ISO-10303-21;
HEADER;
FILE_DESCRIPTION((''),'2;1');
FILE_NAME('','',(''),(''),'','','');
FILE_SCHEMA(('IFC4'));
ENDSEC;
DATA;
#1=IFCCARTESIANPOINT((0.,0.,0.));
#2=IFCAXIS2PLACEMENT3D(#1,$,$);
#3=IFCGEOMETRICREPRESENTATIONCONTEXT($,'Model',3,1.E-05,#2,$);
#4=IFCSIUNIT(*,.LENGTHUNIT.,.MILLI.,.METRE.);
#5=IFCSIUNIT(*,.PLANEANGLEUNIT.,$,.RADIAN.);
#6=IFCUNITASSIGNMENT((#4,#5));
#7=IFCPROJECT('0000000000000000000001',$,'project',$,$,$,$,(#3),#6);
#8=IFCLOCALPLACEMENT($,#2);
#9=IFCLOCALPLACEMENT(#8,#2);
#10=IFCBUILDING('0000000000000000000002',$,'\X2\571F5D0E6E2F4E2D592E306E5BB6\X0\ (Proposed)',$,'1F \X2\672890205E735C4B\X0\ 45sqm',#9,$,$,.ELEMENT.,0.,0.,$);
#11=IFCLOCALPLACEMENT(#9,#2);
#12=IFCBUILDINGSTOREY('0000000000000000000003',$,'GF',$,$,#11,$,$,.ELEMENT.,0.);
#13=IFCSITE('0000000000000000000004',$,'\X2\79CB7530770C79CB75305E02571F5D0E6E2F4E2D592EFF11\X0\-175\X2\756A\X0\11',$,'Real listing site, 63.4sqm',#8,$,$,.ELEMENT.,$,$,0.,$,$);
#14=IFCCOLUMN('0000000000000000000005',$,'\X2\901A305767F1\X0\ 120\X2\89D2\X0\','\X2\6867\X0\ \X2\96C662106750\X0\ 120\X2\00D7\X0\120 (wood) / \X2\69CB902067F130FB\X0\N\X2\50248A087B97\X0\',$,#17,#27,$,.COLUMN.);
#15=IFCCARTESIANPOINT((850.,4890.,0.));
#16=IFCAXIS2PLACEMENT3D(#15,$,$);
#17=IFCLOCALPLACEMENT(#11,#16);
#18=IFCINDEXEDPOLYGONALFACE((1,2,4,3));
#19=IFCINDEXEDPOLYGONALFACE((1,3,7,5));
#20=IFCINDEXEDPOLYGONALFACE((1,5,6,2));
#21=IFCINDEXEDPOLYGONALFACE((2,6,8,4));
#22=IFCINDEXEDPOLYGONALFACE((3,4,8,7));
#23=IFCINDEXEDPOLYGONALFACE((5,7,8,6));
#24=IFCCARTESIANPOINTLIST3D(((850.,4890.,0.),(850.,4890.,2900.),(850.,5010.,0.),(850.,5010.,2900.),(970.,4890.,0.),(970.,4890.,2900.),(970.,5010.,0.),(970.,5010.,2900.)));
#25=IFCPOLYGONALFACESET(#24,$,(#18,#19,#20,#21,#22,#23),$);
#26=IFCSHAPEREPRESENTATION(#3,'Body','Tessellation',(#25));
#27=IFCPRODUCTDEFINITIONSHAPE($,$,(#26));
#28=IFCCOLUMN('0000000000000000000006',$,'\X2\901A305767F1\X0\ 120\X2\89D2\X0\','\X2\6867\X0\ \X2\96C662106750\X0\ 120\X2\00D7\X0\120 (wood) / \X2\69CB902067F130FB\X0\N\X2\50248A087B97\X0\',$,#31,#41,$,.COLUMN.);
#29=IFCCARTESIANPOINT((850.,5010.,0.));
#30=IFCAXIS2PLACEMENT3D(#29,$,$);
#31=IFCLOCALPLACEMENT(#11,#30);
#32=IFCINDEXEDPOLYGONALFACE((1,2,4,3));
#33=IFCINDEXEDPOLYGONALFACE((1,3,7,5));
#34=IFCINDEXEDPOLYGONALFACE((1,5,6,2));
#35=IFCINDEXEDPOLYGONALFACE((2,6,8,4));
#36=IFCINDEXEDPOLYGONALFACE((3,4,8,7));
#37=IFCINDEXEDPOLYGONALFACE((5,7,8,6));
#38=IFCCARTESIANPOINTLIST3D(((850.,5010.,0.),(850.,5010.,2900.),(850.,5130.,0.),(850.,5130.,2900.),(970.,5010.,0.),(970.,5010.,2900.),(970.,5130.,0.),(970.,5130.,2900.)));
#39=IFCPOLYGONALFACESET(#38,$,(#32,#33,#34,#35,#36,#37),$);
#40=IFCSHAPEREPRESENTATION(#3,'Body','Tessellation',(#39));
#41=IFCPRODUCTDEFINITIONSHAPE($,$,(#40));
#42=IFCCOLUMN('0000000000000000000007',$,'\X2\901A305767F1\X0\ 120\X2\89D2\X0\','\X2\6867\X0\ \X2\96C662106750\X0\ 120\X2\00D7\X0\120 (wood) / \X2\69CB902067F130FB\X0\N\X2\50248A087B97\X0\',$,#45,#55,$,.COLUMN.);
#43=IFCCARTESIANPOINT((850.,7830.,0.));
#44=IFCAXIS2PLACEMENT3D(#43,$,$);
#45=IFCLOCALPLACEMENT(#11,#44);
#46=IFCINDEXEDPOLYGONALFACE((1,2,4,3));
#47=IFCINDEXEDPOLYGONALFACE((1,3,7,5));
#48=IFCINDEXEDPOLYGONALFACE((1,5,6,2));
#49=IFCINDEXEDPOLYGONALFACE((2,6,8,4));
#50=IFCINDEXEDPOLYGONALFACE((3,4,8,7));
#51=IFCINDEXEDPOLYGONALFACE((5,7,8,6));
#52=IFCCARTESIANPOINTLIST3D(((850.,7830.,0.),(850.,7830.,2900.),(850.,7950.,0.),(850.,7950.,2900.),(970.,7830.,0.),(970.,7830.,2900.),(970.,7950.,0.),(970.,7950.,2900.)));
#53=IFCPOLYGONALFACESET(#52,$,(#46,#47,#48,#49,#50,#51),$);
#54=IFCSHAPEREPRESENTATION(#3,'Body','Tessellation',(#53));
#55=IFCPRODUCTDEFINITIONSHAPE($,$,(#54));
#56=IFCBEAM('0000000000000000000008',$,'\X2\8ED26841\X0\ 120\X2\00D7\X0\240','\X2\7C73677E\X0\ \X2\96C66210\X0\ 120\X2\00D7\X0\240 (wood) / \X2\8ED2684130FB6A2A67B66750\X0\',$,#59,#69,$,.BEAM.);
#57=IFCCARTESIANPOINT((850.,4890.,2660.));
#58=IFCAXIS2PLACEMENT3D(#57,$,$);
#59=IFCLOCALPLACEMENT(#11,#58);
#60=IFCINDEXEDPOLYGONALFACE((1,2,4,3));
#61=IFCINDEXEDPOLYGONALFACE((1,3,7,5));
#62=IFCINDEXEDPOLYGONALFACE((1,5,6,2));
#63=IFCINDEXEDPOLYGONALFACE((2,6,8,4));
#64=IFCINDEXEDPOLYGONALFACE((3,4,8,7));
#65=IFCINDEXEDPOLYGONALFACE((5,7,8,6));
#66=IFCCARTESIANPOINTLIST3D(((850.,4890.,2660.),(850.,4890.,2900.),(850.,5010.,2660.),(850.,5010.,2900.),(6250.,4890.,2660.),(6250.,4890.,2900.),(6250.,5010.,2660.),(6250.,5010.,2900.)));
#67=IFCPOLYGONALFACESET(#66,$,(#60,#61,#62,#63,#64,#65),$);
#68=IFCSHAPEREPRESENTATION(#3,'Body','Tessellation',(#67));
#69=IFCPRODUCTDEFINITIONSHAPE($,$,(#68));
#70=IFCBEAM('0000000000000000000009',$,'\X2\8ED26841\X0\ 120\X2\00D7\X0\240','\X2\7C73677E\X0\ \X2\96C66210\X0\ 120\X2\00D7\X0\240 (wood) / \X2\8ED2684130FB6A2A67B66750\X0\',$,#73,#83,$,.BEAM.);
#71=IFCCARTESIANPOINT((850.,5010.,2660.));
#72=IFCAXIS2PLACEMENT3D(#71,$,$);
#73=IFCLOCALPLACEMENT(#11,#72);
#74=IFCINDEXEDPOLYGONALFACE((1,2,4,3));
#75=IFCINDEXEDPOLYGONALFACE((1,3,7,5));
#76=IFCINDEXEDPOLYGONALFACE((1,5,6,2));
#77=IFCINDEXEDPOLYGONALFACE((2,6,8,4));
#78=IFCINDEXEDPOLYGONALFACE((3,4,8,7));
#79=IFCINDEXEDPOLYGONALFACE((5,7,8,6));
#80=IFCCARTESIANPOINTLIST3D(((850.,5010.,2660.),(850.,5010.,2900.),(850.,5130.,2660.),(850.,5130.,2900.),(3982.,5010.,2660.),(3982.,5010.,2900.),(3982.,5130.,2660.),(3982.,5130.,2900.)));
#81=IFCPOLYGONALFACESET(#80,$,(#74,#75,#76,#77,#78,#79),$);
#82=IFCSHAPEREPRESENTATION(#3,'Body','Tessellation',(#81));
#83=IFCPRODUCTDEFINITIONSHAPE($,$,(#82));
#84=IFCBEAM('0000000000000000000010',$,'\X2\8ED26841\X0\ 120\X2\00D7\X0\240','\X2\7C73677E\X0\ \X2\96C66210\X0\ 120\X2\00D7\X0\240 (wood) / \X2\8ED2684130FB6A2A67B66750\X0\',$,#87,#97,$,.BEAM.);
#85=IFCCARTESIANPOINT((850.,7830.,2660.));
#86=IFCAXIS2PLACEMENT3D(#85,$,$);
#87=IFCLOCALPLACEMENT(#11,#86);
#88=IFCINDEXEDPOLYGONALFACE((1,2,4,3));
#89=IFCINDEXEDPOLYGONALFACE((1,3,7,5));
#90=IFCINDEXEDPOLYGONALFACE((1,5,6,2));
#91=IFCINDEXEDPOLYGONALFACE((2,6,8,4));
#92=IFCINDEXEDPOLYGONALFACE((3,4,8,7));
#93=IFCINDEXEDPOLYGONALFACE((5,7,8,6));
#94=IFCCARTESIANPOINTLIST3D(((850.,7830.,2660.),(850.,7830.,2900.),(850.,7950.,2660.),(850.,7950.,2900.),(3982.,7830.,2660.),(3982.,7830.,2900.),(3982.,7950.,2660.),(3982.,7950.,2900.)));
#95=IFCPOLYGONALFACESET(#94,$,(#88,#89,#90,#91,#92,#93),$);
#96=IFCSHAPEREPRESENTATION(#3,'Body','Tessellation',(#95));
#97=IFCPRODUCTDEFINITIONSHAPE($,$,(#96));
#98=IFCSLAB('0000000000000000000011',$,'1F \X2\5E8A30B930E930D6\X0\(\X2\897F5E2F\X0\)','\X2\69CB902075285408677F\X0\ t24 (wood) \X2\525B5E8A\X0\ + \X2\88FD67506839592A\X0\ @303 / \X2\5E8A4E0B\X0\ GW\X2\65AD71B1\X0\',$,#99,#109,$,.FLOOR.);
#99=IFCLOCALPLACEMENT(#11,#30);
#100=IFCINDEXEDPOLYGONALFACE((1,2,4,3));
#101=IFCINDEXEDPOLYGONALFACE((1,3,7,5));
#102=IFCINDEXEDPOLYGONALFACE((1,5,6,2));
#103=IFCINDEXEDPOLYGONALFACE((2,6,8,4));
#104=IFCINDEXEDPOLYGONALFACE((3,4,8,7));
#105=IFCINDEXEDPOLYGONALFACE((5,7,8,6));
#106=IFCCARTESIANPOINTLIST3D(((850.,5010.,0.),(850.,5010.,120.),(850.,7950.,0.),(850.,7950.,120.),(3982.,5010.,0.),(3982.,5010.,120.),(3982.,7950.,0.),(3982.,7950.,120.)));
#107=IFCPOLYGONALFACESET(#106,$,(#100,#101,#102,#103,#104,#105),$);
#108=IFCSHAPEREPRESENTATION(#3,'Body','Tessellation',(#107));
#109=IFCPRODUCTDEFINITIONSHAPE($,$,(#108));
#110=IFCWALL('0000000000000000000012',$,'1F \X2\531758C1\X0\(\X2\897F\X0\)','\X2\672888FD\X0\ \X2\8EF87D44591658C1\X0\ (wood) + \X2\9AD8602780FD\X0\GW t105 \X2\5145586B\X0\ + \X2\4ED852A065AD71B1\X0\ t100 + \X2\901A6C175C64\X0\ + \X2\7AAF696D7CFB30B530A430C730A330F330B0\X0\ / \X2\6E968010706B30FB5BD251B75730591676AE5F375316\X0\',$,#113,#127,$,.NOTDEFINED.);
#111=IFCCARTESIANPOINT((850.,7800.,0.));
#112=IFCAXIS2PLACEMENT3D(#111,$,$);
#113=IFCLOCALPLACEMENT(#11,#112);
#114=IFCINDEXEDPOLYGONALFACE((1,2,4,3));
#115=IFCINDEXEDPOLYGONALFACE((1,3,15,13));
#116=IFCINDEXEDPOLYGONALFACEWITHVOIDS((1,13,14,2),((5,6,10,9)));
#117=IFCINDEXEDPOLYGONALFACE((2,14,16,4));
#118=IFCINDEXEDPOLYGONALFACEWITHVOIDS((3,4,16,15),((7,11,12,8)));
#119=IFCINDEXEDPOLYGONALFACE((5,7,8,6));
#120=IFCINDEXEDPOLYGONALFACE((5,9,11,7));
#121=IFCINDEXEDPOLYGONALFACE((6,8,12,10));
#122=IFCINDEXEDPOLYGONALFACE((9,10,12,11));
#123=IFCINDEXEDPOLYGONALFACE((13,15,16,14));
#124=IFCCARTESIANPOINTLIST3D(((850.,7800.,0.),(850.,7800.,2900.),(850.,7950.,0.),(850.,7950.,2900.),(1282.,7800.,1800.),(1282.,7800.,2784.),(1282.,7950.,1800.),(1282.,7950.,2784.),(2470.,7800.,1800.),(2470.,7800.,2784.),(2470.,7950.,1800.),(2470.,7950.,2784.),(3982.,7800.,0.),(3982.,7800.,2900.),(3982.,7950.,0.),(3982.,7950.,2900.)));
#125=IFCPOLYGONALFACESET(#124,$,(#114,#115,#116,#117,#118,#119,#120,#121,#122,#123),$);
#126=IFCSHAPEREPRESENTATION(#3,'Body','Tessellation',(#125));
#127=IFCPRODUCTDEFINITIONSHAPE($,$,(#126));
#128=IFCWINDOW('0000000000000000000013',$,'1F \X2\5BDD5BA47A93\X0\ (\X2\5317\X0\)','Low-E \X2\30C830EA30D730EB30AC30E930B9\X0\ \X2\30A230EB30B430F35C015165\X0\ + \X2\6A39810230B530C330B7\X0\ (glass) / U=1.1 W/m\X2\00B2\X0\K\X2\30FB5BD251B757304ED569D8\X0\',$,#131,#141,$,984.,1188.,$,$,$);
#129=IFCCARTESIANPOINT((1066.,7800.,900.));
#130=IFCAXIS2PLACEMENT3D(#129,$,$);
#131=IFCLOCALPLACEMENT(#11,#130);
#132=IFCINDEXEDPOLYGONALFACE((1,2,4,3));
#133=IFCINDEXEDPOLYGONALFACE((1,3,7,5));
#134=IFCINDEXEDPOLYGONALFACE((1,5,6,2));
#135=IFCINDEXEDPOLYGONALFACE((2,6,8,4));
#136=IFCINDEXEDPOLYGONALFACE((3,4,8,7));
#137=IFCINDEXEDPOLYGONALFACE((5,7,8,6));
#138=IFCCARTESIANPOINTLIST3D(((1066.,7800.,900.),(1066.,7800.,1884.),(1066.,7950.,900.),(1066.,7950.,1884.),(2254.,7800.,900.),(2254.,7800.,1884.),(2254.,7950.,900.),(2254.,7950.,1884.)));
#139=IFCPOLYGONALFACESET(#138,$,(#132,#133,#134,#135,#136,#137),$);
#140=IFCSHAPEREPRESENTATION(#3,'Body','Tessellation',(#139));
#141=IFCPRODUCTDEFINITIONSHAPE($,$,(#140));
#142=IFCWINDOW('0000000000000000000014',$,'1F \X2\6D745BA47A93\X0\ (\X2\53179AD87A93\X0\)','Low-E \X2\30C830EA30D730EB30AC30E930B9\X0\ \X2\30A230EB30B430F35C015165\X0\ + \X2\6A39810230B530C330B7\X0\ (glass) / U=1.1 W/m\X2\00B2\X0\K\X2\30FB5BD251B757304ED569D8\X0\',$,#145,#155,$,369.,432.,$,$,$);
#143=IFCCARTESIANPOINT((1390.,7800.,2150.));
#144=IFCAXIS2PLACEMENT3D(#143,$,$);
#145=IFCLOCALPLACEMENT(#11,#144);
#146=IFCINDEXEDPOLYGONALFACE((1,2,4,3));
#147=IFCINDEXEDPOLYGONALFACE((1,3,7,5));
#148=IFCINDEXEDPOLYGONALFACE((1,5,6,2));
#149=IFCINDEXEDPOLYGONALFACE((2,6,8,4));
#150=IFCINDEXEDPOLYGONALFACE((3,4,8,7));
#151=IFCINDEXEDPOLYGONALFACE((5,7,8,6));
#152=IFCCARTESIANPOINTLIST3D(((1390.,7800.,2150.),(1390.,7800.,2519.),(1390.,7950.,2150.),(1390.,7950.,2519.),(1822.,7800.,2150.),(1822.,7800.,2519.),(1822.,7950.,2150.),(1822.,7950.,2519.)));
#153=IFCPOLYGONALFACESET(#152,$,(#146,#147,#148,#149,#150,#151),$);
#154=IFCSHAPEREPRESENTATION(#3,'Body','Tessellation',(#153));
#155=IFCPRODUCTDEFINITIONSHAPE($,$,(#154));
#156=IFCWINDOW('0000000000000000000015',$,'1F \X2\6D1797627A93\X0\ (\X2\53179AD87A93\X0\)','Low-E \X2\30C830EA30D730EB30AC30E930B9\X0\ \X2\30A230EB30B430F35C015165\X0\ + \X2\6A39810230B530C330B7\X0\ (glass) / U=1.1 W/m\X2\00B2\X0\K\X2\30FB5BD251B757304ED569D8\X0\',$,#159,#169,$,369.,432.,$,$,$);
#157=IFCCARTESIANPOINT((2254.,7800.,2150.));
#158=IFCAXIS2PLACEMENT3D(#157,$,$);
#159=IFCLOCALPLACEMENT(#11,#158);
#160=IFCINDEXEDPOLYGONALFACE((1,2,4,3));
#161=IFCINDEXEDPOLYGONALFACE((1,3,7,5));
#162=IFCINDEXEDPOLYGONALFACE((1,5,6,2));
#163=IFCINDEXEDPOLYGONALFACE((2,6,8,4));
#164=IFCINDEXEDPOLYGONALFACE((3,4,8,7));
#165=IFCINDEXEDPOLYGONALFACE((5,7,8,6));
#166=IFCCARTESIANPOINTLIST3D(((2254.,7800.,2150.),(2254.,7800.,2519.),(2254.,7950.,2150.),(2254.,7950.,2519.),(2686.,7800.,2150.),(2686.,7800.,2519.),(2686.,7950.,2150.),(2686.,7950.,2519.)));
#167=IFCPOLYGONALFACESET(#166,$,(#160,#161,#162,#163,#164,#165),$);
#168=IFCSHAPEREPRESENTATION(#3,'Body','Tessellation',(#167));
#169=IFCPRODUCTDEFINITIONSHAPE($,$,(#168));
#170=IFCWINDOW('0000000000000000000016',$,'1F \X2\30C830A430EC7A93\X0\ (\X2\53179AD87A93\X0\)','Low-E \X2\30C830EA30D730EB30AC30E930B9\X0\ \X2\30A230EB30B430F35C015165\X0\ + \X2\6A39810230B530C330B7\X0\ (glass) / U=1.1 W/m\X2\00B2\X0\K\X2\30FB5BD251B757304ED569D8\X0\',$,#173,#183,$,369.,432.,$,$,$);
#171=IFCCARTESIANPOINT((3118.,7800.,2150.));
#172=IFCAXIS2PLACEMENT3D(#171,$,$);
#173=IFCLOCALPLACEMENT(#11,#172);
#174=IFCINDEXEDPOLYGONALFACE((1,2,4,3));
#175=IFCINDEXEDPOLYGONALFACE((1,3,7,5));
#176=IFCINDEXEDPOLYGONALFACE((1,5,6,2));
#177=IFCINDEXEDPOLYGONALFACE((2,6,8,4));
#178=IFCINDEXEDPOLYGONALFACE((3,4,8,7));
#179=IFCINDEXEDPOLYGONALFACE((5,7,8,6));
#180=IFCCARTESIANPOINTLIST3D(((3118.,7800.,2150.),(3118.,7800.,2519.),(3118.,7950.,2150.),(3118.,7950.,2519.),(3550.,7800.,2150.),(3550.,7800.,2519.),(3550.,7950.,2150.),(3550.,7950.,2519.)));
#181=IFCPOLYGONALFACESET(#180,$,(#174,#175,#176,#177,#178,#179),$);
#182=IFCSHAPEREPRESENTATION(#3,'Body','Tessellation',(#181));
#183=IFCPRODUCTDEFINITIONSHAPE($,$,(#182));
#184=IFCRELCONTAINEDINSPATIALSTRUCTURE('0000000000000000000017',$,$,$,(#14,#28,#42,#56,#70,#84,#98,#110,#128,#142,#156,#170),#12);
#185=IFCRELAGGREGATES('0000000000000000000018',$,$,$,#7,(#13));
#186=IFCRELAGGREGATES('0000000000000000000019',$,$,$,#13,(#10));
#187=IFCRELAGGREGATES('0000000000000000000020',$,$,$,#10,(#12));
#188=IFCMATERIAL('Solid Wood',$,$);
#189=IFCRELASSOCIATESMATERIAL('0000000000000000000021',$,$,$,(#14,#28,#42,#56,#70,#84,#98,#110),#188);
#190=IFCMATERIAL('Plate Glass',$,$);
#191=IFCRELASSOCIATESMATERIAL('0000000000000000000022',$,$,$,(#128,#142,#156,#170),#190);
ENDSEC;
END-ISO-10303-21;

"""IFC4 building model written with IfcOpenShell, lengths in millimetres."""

from ifc_helpers import new_model, si_unit, frame, frame_2d, origin, place, context, project, spatial, rectangle, extrude, material, element, fill, save


model = new_model("IFC4")

# Units and contexts
model_context = context("Model", 3, precision=1e-05, world=origin())
ifc_project = project(units=[si_unit("LENGTHUNIT", "METRE", prefix="MILLI"), si_unit("PLANEANGLEUNIT", "RADIAN")], contexts=[model_context])

# Site, building, storey
site_placement = place(None, origin())
site = spatial("IfcSite", under=ifc_project, at=site_placement, Name="秋田県秋田市土崎港中央１-175番11", ObjectType="Real listing site, 63.4sqm", CompositionType="ELEMENT", RefElevation=0.0)
building_placement = place(site_placement, origin())
building = spatial("IfcBuilding", under=site, at=building_placement, Name="土崎港中央の家 (Proposed)", ObjectType="1F 木造平屋 45sqm", CompositionType="ELEMENT", ElevationOfRefHeight=0.0, ElevationOfTerrain=0.0)
storey_placement = place(building_placement, origin())
storey = spatial("IfcBuildingStorey", under=building, at=storey_placement, Name="GF", CompositionType="ELEMENT", Elevation=0.0)

# Columns
ifc_material_1 = material(Name="Solid Wood")
column_1_placement = place(storey_placement, frame((850.0, 4890.0, 0.0)))
element("IfcColumn", 1, at=column_1_placement, inside=storey, material=ifc_material_1, Name="通し柱 120角", Description="桧 集成材 120×120 (wood) / 構造柱・N値計算", PredefinedType="COLUMN", context=model_context, shape_type="SweptSolid", body=[
    extrude(rectangle(XDim=120.0, YDim=120.0, at=frame_2d((60.0, 60.0))), frame((850.0, 4890.0, 0.0)), (0.0, 0.0, 1.0), 2900.0),
])
column_2_placement = place(storey_placement, frame((850.0, 5010.0, 0.0)))
element("IfcColumn", 2, at=column_2_placement, inside=storey, material=ifc_material_1, Name="通し柱 120角", Description="桧 集成材 120×120 (wood) / 構造柱・N値計算", PredefinedType="COLUMN", context=model_context, shape_type="SweptSolid", body=[
    extrude(rectangle(XDim=120.0, YDim=120.0, at=frame_2d((60.0, 60.0))), frame((850.0, 5010.0, 0.0)), (0.0, 0.0, 1.0), 2900.0),
])
column_3_placement = place(storey_placement, frame((850.0, 7830.0, 0.0)))
element("IfcColumn", 3, at=column_3_placement, inside=storey, material=ifc_material_1, Name="通し柱 120角", Description="桧 集成材 120×120 (wood) / 構造柱・N値計算", PredefinedType="COLUMN", context=model_context, shape_type="SweptSolid", body=[
    extrude(rectangle(XDim=120.0, YDim=120.0, at=frame_2d((60.0, 60.0))), frame((850.0, 7830.0, 0.0)), (0.0, 0.0, 1.0), 2900.0),
])

# Beams
beam_1_placement = place(storey_placement, frame((850.0, 4890.0, 2660.0)))
element("IfcBeam", 4, at=beam_1_placement, inside=storey, material=ifc_material_1, Name="軒桁 120×240", Description="米松 集成 120×240 (wood) / 軒桁・横架材", PredefinedType="BEAM", context=model_context, shape_type="SweptSolid", body=[
    extrude(rectangle(XDim=5400.0, YDim=120.0, at=frame_2d((2700.0, 60.0))), frame((850.0, 4890.0, 2660.0)), (0.0, 0.0, 1.0), 240.0),
])
beam_2_placement = place(storey_placement, frame((850.0, 5010.0, 2660.0)))
element("IfcBeam", 5, at=beam_2_placement, inside=storey, material=ifc_material_1, Name="軒桁 120×240", Description="米松 集成 120×240 (wood) / 軒桁・横架材", PredefinedType="BEAM", context=model_context, shape_type="SweptSolid", body=[
    extrude(rectangle(XDim=3132.0, YDim=120.0, at=frame_2d((1566.0, 60.0))), frame((850.0, 5010.0, 2660.0)), (0.0, 0.0, 1.0), 240.0),
])
beam_3_placement = place(storey_placement, frame((850.0, 7830.0, 2660.0)))
element("IfcBeam", 6, at=beam_3_placement, inside=storey, material=ifc_material_1, Name="軒桁 120×240", Description="米松 集成 120×240 (wood) / 軒桁・横架材", PredefinedType="BEAM", context=model_context, shape_type="SweptSolid", body=[
    extrude(rectangle(XDim=3132.0, YDim=120.0, at=frame_2d((1566.0, 60.0))), frame((850.0, 7830.0, 2660.0)), (0.0, 0.0, 1.0), 240.0),
])

# Slab
slab_placement = place(storey_placement, frame((850.0, 5010.0, 0.0)))
element("IfcSlab", 7, at=slab_placement, inside=storey, material=ifc_material_1, Name="1F 床スラブ(西帯)", Description="構造用合板 t24 (wood) 剛床 + 製材根太 @303 / 床下 GW断熱", PredefinedType="FLOOR", context=model_context, shape_type="SweptSolid", body=[
    extrude(rectangle(XDim=3132.0, YDim=2940.0, at=frame_2d((1566.0, 1470.0))), frame((850.0, 5010.0, 0.0)), (0.0, 0.0, 1.0), 120.0),
])

# Wall, openings, windows
wall_1_placement = place(storey_placement, frame((850.0, 7800.0, 0.0)))
wall_1 = element("IfcWall", 8, at=wall_1_placement, inside=storey, material=ifc_material_1, Name="1F 北壁(西)", Description="木製 軸組外壁 (wood) + 高性能GW t105 充填 + 付加断熱 t100 + 通気層 + 窯業系サイディング / 準耐火・寒冷地外皮強化", PredefinedType="NOTDEFINED", context=model_context, shape_type="SweptSolid", body=[
    extrude(rectangle(XDim=3132.0, YDim=150.0, at=frame_2d((1566.0, 75.0))), frame((850.0, 7800.0, 0.0)), (0.0, 0.0, 1.0), 2900.0),
])
opening_1_placement = place(storey_placement, frame((1066.0, 7800.0, 900.0)))
opening_1 = element("IfcOpeningElement", 9, at=opening_1_placement, cuts=wall_1, PredefinedType="NOTDEFINED", context=model_context, shape_type="SweptSolid", body=[
    extrude(rectangle(XDim=1188.0, YDim=150.0, at=frame_2d((594.0, 75.0))), frame((1066.0, 7800.0, 900.0)), (0.0, 0.0, 1.0), 984.0),
])
opening_2_placement = place(storey_placement, frame((1390.0, 7800.0, 2150.0)))
opening_2 = element("IfcOpeningElement", 10, at=opening_2_placement, cuts=wall_1, PredefinedType="NOTDEFINED", context=model_context, shape_type="SweptSolid", body=[
    extrude(rectangle(XDim=432.0, YDim=150.0, at=frame_2d((216.0, 75.0))), frame((1390.0, 7800.0, 2150.0)), (0.0, 0.0, 1.0), 369.0),
])
opening_3_placement = place(storey_placement, frame((2254.0, 7800.0, 2150.0)))
opening_3 = element("IfcOpeningElement", 11, at=opening_3_placement, cuts=wall_1, PredefinedType="NOTDEFINED", context=model_context, shape_type="SweptSolid", body=[
    extrude(rectangle(XDim=432.0, YDim=150.0, at=frame_2d((216.0, 75.0))), frame((2254.0, 7800.0, 2150.0)), (0.0, 0.0, 1.0), 369.0),
])
opening_4_placement = place(storey_placement, frame((3118.0, 7800.0, 2150.0)))
opening_4 = element("IfcOpeningElement", 12, at=opening_4_placement, cuts=wall_1, PredefinedType="NOTDEFINED", context=model_context, shape_type="SweptSolid", body=[
    extrude(rectangle(XDim=432.0, YDim=150.0, at=frame_2d((216.0, 75.0))), frame((3118.0, 7800.0, 2150.0)), (0.0, 0.0, 1.0), 369.0),
])
ifc_material_2 = material(Name="Plate Glass")
window_1_placement = place(storey_placement, frame((1066.0, 7800.0, 900.0)))
window_1 = element("IfcWindow", 13, at=window_1_placement, inside=storey, material=ifc_material_2, Name="1F 寝室窓 (北)", Description="Low-E トリプルガラス アルゴン封入 + 樹脂サッシ (glass) / U=1.1 W/m²K・寒冷地仕様", OverallHeight=984.0, OverallWidth=1188.0, context=model_context, shape_type="SweptSolid", body=[
    extrude(rectangle(XDim=1188.0, YDim=150.0, at=frame_2d((594.0, 75.0))), frame((1066.0, 7800.0, 900.0)), (0.0, 0.0, 1.0), 984.0),
])
fill(opening_1, window_1)
window_2_placement = place(storey_placement, frame((1390.0, 7800.0, 2150.0)))
window_2 = element("IfcWindow", 14, at=window_2_placement, inside=storey, material=ifc_material_2, Name="1F 浴室窓 (北高窓)", Description="Low-E トリプルガラス アルゴン封入 + 樹脂サッシ (glass) / U=1.1 W/m²K・寒冷地仕様", OverallHeight=369.0, OverallWidth=432.0, context=model_context, shape_type="SweptSolid", body=[
    extrude(rectangle(XDim=432.0, YDim=150.0, at=frame_2d((216.0, 75.0))), frame((1390.0, 7800.0, 2150.0)), (0.0, 0.0, 1.0), 369.0),
])
fill(opening_2, window_2)
window_3_placement = place(storey_placement, frame((2254.0, 7800.0, 2150.0)))
window_3 = element("IfcWindow", 15, at=window_3_placement, inside=storey, material=ifc_material_2, Name="1F 洗面窓 (北高窓)", Description="Low-E トリプルガラス アルゴン封入 + 樹脂サッシ (glass) / U=1.1 W/m²K・寒冷地仕様", OverallHeight=369.0, OverallWidth=432.0, context=model_context, shape_type="SweptSolid", body=[
    extrude(rectangle(XDim=432.0, YDim=150.0, at=frame_2d((216.0, 75.0))), frame((2254.0, 7800.0, 2150.0)), (0.0, 0.0, 1.0), 369.0),
])
fill(opening_3, window_3)
window_4_placement = place(storey_placement, frame((3118.0, 7800.0, 2150.0)))
window_4 = element("IfcWindow", 16, at=window_4_placement, inside=storey, material=ifc_material_2, Name="1F トイレ窓 (北高窓)", Description="Low-E トリプルガラス アルゴン封入 + 樹脂サッシ (glass) / U=1.1 W/m²K・寒冷地仕様", OverallHeight=369.0, OverallWidth=432.0, context=model_context, shape_type="SweptSolid", body=[
    extrude(rectangle(XDim=432.0, YDim=150.0, at=frame_2d((216.0, 75.0))), frame((3118.0, 7800.0, 2150.0)), (0.0, 0.0, 1.0), 369.0),
])
fill(opening_4, window_4)

save(model, "model.ifc")
